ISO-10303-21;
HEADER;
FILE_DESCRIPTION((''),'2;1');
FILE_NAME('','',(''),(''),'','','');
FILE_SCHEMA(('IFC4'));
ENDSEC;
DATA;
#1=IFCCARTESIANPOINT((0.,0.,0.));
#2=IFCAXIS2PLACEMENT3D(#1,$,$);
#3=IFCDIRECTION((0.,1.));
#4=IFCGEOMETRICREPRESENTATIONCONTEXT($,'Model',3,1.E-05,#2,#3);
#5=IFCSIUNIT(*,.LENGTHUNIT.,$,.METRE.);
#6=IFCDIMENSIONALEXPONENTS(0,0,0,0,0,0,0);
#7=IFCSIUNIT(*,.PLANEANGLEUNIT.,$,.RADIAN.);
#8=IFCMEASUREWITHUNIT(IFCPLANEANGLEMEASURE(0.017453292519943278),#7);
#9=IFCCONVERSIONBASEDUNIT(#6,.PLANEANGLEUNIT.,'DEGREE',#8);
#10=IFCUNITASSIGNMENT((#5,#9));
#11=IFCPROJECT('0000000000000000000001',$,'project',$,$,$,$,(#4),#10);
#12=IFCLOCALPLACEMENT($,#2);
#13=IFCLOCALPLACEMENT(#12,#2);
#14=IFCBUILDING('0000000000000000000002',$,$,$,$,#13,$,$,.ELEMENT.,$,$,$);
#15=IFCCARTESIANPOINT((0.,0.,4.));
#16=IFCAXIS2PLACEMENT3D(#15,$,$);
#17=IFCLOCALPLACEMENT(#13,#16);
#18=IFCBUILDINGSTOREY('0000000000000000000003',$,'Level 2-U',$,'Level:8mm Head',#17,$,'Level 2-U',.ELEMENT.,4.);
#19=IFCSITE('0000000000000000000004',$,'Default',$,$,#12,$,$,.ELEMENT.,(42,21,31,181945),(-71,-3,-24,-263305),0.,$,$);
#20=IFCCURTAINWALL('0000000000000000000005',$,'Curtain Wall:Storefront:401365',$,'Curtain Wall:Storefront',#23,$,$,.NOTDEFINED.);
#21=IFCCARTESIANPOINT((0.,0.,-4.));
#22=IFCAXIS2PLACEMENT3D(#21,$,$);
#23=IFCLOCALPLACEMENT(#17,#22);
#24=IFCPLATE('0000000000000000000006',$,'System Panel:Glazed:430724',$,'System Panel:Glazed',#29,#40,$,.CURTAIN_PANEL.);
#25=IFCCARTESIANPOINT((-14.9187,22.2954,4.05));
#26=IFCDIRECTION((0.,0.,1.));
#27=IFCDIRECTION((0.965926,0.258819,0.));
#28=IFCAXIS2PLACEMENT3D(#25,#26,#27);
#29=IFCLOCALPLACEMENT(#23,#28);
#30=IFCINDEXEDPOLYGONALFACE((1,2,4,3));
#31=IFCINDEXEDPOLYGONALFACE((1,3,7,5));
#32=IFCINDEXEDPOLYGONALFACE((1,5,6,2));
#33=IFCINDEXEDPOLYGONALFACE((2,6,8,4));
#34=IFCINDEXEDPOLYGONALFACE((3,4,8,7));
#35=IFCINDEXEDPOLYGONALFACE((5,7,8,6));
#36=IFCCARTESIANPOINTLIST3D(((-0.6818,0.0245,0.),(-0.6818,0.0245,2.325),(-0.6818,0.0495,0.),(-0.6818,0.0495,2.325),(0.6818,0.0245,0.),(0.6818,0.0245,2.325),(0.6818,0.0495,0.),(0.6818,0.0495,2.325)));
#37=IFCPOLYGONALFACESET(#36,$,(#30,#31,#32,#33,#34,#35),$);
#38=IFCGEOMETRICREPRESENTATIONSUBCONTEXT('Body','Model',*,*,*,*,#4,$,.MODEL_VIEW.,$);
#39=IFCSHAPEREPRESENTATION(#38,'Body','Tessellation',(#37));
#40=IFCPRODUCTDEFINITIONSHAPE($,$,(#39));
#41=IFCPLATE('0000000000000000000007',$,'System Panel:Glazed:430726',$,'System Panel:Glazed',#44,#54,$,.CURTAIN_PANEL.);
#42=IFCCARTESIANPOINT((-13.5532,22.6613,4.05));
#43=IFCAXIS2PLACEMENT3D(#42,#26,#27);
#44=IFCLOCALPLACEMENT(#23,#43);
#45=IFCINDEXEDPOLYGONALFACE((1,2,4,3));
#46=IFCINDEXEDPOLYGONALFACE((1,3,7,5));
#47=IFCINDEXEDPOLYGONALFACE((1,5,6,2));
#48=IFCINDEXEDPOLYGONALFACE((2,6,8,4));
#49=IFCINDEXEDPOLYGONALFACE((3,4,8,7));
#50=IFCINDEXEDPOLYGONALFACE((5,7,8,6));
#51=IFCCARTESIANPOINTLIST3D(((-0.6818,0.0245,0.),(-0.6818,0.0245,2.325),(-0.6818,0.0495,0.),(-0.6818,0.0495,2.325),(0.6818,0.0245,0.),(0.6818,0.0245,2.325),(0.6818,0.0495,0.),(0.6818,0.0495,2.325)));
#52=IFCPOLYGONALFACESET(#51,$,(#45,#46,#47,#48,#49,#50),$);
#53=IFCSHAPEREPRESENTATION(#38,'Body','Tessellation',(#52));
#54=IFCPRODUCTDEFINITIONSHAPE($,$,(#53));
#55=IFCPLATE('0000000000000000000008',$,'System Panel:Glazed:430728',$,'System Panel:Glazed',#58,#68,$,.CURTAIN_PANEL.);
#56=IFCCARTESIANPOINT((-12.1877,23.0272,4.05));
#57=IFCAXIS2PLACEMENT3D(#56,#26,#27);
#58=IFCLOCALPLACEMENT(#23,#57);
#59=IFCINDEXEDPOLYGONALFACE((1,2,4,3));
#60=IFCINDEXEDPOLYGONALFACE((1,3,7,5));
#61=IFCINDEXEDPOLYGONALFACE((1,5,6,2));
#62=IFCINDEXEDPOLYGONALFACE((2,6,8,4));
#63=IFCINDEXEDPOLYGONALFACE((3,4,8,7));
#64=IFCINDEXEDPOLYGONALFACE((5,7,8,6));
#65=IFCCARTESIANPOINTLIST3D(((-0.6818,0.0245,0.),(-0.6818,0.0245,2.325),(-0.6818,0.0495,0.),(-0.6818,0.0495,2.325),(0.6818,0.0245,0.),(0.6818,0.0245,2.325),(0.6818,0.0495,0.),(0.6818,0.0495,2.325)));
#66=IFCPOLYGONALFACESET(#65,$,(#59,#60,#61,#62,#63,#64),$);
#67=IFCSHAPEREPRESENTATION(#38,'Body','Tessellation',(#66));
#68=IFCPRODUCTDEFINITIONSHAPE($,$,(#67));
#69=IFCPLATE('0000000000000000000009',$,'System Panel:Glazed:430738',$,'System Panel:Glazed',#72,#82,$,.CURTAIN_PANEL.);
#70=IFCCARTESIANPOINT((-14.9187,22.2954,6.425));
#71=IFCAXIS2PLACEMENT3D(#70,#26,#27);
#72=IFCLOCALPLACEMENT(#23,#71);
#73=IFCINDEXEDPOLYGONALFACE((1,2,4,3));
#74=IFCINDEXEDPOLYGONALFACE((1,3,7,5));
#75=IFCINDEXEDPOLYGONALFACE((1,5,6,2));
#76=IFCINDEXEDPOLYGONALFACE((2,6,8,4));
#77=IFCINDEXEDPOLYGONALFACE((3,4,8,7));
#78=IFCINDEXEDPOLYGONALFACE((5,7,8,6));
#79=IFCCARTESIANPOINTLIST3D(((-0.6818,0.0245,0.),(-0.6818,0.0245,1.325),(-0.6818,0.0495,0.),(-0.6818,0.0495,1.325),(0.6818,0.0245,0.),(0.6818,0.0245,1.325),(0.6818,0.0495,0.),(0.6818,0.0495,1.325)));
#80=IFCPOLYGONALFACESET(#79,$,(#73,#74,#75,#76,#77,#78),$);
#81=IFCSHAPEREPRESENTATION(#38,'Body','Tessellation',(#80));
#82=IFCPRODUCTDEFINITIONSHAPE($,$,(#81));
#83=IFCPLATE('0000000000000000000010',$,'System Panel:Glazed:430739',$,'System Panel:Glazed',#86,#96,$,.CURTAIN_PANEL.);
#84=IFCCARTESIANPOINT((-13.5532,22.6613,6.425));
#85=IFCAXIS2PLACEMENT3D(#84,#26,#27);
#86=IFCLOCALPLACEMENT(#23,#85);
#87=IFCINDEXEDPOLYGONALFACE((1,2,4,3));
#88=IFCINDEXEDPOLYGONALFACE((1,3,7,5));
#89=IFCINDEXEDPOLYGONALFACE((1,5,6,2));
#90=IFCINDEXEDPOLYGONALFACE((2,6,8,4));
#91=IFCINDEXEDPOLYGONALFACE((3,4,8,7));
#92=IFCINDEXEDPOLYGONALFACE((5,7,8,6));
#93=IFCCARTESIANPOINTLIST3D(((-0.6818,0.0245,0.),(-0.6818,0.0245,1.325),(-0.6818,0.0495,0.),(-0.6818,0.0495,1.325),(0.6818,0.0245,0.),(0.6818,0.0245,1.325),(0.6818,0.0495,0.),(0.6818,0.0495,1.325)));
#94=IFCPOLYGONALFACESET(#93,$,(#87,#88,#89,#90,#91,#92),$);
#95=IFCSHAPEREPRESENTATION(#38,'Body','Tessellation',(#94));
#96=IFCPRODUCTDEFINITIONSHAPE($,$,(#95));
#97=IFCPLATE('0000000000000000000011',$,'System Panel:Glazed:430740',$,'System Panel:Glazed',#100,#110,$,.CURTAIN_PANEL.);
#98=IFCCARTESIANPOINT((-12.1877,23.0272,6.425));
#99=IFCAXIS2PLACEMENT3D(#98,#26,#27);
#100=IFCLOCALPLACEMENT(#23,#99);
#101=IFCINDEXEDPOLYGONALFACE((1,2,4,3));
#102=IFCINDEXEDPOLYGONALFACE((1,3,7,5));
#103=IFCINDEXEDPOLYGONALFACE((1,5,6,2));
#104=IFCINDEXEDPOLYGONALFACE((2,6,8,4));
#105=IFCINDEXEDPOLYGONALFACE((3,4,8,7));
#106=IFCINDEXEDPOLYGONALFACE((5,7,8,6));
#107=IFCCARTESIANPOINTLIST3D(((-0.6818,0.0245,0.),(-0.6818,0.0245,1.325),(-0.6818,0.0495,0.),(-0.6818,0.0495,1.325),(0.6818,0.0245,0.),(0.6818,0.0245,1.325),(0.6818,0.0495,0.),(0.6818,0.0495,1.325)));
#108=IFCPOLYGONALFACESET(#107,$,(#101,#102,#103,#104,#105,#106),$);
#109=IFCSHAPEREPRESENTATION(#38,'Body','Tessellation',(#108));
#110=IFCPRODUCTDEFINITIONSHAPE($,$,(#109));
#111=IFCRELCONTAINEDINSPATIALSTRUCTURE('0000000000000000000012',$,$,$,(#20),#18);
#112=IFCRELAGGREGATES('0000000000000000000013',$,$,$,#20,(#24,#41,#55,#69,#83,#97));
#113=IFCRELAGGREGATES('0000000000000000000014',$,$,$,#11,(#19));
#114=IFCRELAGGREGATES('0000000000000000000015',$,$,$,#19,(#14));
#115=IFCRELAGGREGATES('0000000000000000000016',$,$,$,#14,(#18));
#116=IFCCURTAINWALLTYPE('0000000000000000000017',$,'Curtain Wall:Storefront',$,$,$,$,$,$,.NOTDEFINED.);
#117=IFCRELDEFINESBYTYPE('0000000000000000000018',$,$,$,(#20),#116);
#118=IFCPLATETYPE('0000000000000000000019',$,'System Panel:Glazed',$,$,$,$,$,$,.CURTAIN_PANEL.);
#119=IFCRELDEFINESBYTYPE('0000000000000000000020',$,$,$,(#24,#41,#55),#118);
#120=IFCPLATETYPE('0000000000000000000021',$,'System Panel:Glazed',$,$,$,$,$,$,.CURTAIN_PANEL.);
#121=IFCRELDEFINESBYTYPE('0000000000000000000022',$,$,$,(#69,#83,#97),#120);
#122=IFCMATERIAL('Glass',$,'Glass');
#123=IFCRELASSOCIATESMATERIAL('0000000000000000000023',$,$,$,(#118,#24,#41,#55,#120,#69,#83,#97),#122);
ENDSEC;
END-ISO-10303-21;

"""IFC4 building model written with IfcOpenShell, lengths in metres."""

from ifc_helpers import new_model, entity, si_unit, converted_unit, direction, frame, origin, place, context, subcontext, project, spatial, indexed_curve, outline, extrude, source, transform, mapped, material, type_object, type_shapes, element, aggregate, save


model = new_model("IFC4")

# Units and contexts
model_context = context("Model", 3, precision=1e-05, world=origin(), true_north=direction((0.0, 1.0)))
body_context = subcontext(model_context, "Body", "Model", "MODEL_VIEW")
ifc_project = project(units=[si_unit("LENGTHUNIT", "METRE"), converted_unit("PLANEANGLEUNIT", "DEGREE", entity("IfcPlaneAngleMeasure", 0.017453292519943278), si_unit("PLANEANGLEUNIT", "RADIAN"), dimensions=[0, 0, 0, 0, 0, 0, 0])], contexts=[model_context])

# Site, building, storey
site_placement = place(None, origin())
site = spatial("IfcSite", under=ifc_project, at=site_placement, Name="Default", CompositionType="ELEMENT", RefLatitude=(42, 21, 31, 181945), RefLongitude=(-71, -3, -24, -263305), RefElevation=0.0)
building_placement = place(site_placement, origin())
building = spatial("IfcBuilding", under=site, at=building_placement, CompositionType="ELEMENT")
storey_placement = place(building_placement, frame((0.0, 0.0, 4.0)))
storey = spatial("IfcBuildingStorey", under=building, at=storey_placement, Name="Level 2-U", ObjectType="Level:8mm Head", LongName="Level 2-U", CompositionType="ELEMENT", Elevation=4.0)

# Curtain wall, plates
curtain_wall_type = type_object("IfcCurtainWallType", Name="Curtain Wall:Storefront", PredefinedType="NOTDEFINED")
curtain_wall_placement = place(storey_placement, frame((0.0, 0.0, -4.0)))
curtain_wall = element("IfcCurtainWall", 1, at=curtain_wall_placement, inside=storey, type_object=curtain_wall_type, Name="Curtain Wall:Storefront:401365", ObjectType="Curtain Wall:Storefront", PredefinedType="NOTDEFINED")
ifc_material_1 = material(Name="Glass", Category="Glass")
plate_type_1 = type_object("IfcPlateType", Name="System Panel:Glazed", PredefinedType="CURTAIN_PANEL", material=ifc_material_1)
shared_shape_1 = source(origin(), body_context, "Body", "SweptSolid", [
    extrude(outline(indexed_curve([(-0.0125, -0.6818), (0.0125, -0.6818), (0.0125, 0.6818), (-0.0125, 0.6818), (-0.0125, -0.6818)], self_intersect=False)), frame((0.0, 0.037, 0.0), z_axis=(0.0, 0.0, 1.0), x_axis=(0.0, 1.0, 0.0)), (0.0, 0.0, 1.0), 2.325),
])
type_shapes(plate_type_1, [shared_shape_1])
plate_1_placement = place(curtain_wall_placement, frame((-14.9187, 22.2954, 4.05), z_axis=(0.0, 0.0, 1.0), x_axis=(0.965926, 0.258819, 0.0)))
plate_1 = element("IfcPlate", 2, at=plate_1_placement, type_object=plate_type_1, material=ifc_material_1, Name="System Panel:Glazed:430724", ObjectType="System Panel:Glazed", PredefinedType="CURTAIN_PANEL", context=body_context, shape_type="MappedRepresentation", body=[
    mapped(shared_shape_1, transform((0.0, 0.0, 0.0), scale=1.0)),
])
plate_2_placement = place(curtain_wall_placement, frame((-13.5532, 22.6613, 4.05), z_axis=(0.0, 0.0, 1.0), x_axis=(0.965926, 0.258819, 0.0)))
plate_2 = element("IfcPlate", 3, at=plate_2_placement, type_object=plate_type_1, material=ifc_material_1, Name="System Panel:Glazed:430726", ObjectType="System Panel:Glazed", PredefinedType="CURTAIN_PANEL", context=body_context, shape_type="MappedRepresentation", body=[
    mapped(shared_shape_1, transform((0.0, 0.0, 0.0), scale=1.0)),
])
plate_3_placement = place(curtain_wall_placement, frame((-12.1877, 23.0272, 4.05), z_axis=(0.0, 0.0, 1.0), x_axis=(0.965926, 0.258819, 0.0)))
plate_3 = element("IfcPlate", 4, at=plate_3_placement, type_object=plate_type_1, material=ifc_material_1, Name="System Panel:Glazed:430728", ObjectType="System Panel:Glazed", PredefinedType="CURTAIN_PANEL", context=body_context, shape_type="MappedRepresentation", body=[
    mapped(shared_shape_1, transform((0.0, 0.0, 0.0), scale=1.0)),
])
plate_type_2 = type_object("IfcPlateType", Name="System Panel:Glazed", PredefinedType="CURTAIN_PANEL", material=ifc_material_1)
shared_shape_2 = source(origin(), body_context, "Body", "SweptSolid", [
    extrude(outline(indexed_curve([(-0.0125, -0.6818), (0.0125, -0.6818), (0.0125, 0.6818), (-0.0125, 0.6818), (-0.0125, -0.6818)], self_intersect=False)), frame((0.0, 0.037, 0.0), z_axis=(0.0, 0.0, 1.0), x_axis=(0.0, 1.0, 0.0)), (0.0, 0.0, 1.0), 1.325),
])
type_shapes(plate_type_2, [shared_shape_2])
plate_4_placement = place(curtain_wall_placement, frame((-14.9187, 22.2954, 6.425), z_axis=(0.0, 0.0, 1.0), x_axis=(0.965926, 0.258819, 0.0)))
plate_4 = element("IfcPlate", 5, at=plate_4_placement, type_object=plate_type_2, material=ifc_material_1, Name="System Panel:Glazed:430738", ObjectType="System Panel:Glazed", PredefinedType="CURTAIN_PANEL", context=body_context, shape_type="MappedRepresentation", body=[
    mapped(shared_shape_2, transform((0.0, 0.0, 0.0), scale=1.0)),
])
plate_5_placement = place(curtain_wall_placement, frame((-13.5532, 22.6613, 6.425), z_axis=(0.0, 0.0, 1.0), x_axis=(0.965926, 0.258819, 0.0)))
plate_5 = element("IfcPlate", 6, at=plate_5_placement, type_object=plate_type_2, material=ifc_material_1, Name="System Panel:Glazed:430739", ObjectType="System Panel:Glazed", PredefinedType="CURTAIN_PANEL", context=body_context, shape_type="MappedRepresentation", body=[
    mapped(shared_shape_2, transform((0.0, 0.0, 0.0), scale=1.0)),
])
plate_6_placement = place(curtain_wall_placement, frame((-12.1877, 23.0272, 6.425), z_axis=(0.0, 0.0, 1.0), x_axis=(0.965926, 0.258819, 0.0)))
plate_6 = element("IfcPlate", 7, at=plate_6_placement, type_object=plate_type_2, material=ifc_material_1, Name="System Panel:Glazed:430740", ObjectType="System Panel:Glazed", PredefinedType="CURTAIN_PANEL", context=body_context, shape_type="MappedRepresentation", body=[
    mapped(shared_shape_2, transform((0.0, 0.0, 0.0), scale=1.0)),
])
aggregate(curtain_wall, [plate_1, plate_2, plate_3, plate_4, plate_5, plate_6])

save(model, "model.ifc")
